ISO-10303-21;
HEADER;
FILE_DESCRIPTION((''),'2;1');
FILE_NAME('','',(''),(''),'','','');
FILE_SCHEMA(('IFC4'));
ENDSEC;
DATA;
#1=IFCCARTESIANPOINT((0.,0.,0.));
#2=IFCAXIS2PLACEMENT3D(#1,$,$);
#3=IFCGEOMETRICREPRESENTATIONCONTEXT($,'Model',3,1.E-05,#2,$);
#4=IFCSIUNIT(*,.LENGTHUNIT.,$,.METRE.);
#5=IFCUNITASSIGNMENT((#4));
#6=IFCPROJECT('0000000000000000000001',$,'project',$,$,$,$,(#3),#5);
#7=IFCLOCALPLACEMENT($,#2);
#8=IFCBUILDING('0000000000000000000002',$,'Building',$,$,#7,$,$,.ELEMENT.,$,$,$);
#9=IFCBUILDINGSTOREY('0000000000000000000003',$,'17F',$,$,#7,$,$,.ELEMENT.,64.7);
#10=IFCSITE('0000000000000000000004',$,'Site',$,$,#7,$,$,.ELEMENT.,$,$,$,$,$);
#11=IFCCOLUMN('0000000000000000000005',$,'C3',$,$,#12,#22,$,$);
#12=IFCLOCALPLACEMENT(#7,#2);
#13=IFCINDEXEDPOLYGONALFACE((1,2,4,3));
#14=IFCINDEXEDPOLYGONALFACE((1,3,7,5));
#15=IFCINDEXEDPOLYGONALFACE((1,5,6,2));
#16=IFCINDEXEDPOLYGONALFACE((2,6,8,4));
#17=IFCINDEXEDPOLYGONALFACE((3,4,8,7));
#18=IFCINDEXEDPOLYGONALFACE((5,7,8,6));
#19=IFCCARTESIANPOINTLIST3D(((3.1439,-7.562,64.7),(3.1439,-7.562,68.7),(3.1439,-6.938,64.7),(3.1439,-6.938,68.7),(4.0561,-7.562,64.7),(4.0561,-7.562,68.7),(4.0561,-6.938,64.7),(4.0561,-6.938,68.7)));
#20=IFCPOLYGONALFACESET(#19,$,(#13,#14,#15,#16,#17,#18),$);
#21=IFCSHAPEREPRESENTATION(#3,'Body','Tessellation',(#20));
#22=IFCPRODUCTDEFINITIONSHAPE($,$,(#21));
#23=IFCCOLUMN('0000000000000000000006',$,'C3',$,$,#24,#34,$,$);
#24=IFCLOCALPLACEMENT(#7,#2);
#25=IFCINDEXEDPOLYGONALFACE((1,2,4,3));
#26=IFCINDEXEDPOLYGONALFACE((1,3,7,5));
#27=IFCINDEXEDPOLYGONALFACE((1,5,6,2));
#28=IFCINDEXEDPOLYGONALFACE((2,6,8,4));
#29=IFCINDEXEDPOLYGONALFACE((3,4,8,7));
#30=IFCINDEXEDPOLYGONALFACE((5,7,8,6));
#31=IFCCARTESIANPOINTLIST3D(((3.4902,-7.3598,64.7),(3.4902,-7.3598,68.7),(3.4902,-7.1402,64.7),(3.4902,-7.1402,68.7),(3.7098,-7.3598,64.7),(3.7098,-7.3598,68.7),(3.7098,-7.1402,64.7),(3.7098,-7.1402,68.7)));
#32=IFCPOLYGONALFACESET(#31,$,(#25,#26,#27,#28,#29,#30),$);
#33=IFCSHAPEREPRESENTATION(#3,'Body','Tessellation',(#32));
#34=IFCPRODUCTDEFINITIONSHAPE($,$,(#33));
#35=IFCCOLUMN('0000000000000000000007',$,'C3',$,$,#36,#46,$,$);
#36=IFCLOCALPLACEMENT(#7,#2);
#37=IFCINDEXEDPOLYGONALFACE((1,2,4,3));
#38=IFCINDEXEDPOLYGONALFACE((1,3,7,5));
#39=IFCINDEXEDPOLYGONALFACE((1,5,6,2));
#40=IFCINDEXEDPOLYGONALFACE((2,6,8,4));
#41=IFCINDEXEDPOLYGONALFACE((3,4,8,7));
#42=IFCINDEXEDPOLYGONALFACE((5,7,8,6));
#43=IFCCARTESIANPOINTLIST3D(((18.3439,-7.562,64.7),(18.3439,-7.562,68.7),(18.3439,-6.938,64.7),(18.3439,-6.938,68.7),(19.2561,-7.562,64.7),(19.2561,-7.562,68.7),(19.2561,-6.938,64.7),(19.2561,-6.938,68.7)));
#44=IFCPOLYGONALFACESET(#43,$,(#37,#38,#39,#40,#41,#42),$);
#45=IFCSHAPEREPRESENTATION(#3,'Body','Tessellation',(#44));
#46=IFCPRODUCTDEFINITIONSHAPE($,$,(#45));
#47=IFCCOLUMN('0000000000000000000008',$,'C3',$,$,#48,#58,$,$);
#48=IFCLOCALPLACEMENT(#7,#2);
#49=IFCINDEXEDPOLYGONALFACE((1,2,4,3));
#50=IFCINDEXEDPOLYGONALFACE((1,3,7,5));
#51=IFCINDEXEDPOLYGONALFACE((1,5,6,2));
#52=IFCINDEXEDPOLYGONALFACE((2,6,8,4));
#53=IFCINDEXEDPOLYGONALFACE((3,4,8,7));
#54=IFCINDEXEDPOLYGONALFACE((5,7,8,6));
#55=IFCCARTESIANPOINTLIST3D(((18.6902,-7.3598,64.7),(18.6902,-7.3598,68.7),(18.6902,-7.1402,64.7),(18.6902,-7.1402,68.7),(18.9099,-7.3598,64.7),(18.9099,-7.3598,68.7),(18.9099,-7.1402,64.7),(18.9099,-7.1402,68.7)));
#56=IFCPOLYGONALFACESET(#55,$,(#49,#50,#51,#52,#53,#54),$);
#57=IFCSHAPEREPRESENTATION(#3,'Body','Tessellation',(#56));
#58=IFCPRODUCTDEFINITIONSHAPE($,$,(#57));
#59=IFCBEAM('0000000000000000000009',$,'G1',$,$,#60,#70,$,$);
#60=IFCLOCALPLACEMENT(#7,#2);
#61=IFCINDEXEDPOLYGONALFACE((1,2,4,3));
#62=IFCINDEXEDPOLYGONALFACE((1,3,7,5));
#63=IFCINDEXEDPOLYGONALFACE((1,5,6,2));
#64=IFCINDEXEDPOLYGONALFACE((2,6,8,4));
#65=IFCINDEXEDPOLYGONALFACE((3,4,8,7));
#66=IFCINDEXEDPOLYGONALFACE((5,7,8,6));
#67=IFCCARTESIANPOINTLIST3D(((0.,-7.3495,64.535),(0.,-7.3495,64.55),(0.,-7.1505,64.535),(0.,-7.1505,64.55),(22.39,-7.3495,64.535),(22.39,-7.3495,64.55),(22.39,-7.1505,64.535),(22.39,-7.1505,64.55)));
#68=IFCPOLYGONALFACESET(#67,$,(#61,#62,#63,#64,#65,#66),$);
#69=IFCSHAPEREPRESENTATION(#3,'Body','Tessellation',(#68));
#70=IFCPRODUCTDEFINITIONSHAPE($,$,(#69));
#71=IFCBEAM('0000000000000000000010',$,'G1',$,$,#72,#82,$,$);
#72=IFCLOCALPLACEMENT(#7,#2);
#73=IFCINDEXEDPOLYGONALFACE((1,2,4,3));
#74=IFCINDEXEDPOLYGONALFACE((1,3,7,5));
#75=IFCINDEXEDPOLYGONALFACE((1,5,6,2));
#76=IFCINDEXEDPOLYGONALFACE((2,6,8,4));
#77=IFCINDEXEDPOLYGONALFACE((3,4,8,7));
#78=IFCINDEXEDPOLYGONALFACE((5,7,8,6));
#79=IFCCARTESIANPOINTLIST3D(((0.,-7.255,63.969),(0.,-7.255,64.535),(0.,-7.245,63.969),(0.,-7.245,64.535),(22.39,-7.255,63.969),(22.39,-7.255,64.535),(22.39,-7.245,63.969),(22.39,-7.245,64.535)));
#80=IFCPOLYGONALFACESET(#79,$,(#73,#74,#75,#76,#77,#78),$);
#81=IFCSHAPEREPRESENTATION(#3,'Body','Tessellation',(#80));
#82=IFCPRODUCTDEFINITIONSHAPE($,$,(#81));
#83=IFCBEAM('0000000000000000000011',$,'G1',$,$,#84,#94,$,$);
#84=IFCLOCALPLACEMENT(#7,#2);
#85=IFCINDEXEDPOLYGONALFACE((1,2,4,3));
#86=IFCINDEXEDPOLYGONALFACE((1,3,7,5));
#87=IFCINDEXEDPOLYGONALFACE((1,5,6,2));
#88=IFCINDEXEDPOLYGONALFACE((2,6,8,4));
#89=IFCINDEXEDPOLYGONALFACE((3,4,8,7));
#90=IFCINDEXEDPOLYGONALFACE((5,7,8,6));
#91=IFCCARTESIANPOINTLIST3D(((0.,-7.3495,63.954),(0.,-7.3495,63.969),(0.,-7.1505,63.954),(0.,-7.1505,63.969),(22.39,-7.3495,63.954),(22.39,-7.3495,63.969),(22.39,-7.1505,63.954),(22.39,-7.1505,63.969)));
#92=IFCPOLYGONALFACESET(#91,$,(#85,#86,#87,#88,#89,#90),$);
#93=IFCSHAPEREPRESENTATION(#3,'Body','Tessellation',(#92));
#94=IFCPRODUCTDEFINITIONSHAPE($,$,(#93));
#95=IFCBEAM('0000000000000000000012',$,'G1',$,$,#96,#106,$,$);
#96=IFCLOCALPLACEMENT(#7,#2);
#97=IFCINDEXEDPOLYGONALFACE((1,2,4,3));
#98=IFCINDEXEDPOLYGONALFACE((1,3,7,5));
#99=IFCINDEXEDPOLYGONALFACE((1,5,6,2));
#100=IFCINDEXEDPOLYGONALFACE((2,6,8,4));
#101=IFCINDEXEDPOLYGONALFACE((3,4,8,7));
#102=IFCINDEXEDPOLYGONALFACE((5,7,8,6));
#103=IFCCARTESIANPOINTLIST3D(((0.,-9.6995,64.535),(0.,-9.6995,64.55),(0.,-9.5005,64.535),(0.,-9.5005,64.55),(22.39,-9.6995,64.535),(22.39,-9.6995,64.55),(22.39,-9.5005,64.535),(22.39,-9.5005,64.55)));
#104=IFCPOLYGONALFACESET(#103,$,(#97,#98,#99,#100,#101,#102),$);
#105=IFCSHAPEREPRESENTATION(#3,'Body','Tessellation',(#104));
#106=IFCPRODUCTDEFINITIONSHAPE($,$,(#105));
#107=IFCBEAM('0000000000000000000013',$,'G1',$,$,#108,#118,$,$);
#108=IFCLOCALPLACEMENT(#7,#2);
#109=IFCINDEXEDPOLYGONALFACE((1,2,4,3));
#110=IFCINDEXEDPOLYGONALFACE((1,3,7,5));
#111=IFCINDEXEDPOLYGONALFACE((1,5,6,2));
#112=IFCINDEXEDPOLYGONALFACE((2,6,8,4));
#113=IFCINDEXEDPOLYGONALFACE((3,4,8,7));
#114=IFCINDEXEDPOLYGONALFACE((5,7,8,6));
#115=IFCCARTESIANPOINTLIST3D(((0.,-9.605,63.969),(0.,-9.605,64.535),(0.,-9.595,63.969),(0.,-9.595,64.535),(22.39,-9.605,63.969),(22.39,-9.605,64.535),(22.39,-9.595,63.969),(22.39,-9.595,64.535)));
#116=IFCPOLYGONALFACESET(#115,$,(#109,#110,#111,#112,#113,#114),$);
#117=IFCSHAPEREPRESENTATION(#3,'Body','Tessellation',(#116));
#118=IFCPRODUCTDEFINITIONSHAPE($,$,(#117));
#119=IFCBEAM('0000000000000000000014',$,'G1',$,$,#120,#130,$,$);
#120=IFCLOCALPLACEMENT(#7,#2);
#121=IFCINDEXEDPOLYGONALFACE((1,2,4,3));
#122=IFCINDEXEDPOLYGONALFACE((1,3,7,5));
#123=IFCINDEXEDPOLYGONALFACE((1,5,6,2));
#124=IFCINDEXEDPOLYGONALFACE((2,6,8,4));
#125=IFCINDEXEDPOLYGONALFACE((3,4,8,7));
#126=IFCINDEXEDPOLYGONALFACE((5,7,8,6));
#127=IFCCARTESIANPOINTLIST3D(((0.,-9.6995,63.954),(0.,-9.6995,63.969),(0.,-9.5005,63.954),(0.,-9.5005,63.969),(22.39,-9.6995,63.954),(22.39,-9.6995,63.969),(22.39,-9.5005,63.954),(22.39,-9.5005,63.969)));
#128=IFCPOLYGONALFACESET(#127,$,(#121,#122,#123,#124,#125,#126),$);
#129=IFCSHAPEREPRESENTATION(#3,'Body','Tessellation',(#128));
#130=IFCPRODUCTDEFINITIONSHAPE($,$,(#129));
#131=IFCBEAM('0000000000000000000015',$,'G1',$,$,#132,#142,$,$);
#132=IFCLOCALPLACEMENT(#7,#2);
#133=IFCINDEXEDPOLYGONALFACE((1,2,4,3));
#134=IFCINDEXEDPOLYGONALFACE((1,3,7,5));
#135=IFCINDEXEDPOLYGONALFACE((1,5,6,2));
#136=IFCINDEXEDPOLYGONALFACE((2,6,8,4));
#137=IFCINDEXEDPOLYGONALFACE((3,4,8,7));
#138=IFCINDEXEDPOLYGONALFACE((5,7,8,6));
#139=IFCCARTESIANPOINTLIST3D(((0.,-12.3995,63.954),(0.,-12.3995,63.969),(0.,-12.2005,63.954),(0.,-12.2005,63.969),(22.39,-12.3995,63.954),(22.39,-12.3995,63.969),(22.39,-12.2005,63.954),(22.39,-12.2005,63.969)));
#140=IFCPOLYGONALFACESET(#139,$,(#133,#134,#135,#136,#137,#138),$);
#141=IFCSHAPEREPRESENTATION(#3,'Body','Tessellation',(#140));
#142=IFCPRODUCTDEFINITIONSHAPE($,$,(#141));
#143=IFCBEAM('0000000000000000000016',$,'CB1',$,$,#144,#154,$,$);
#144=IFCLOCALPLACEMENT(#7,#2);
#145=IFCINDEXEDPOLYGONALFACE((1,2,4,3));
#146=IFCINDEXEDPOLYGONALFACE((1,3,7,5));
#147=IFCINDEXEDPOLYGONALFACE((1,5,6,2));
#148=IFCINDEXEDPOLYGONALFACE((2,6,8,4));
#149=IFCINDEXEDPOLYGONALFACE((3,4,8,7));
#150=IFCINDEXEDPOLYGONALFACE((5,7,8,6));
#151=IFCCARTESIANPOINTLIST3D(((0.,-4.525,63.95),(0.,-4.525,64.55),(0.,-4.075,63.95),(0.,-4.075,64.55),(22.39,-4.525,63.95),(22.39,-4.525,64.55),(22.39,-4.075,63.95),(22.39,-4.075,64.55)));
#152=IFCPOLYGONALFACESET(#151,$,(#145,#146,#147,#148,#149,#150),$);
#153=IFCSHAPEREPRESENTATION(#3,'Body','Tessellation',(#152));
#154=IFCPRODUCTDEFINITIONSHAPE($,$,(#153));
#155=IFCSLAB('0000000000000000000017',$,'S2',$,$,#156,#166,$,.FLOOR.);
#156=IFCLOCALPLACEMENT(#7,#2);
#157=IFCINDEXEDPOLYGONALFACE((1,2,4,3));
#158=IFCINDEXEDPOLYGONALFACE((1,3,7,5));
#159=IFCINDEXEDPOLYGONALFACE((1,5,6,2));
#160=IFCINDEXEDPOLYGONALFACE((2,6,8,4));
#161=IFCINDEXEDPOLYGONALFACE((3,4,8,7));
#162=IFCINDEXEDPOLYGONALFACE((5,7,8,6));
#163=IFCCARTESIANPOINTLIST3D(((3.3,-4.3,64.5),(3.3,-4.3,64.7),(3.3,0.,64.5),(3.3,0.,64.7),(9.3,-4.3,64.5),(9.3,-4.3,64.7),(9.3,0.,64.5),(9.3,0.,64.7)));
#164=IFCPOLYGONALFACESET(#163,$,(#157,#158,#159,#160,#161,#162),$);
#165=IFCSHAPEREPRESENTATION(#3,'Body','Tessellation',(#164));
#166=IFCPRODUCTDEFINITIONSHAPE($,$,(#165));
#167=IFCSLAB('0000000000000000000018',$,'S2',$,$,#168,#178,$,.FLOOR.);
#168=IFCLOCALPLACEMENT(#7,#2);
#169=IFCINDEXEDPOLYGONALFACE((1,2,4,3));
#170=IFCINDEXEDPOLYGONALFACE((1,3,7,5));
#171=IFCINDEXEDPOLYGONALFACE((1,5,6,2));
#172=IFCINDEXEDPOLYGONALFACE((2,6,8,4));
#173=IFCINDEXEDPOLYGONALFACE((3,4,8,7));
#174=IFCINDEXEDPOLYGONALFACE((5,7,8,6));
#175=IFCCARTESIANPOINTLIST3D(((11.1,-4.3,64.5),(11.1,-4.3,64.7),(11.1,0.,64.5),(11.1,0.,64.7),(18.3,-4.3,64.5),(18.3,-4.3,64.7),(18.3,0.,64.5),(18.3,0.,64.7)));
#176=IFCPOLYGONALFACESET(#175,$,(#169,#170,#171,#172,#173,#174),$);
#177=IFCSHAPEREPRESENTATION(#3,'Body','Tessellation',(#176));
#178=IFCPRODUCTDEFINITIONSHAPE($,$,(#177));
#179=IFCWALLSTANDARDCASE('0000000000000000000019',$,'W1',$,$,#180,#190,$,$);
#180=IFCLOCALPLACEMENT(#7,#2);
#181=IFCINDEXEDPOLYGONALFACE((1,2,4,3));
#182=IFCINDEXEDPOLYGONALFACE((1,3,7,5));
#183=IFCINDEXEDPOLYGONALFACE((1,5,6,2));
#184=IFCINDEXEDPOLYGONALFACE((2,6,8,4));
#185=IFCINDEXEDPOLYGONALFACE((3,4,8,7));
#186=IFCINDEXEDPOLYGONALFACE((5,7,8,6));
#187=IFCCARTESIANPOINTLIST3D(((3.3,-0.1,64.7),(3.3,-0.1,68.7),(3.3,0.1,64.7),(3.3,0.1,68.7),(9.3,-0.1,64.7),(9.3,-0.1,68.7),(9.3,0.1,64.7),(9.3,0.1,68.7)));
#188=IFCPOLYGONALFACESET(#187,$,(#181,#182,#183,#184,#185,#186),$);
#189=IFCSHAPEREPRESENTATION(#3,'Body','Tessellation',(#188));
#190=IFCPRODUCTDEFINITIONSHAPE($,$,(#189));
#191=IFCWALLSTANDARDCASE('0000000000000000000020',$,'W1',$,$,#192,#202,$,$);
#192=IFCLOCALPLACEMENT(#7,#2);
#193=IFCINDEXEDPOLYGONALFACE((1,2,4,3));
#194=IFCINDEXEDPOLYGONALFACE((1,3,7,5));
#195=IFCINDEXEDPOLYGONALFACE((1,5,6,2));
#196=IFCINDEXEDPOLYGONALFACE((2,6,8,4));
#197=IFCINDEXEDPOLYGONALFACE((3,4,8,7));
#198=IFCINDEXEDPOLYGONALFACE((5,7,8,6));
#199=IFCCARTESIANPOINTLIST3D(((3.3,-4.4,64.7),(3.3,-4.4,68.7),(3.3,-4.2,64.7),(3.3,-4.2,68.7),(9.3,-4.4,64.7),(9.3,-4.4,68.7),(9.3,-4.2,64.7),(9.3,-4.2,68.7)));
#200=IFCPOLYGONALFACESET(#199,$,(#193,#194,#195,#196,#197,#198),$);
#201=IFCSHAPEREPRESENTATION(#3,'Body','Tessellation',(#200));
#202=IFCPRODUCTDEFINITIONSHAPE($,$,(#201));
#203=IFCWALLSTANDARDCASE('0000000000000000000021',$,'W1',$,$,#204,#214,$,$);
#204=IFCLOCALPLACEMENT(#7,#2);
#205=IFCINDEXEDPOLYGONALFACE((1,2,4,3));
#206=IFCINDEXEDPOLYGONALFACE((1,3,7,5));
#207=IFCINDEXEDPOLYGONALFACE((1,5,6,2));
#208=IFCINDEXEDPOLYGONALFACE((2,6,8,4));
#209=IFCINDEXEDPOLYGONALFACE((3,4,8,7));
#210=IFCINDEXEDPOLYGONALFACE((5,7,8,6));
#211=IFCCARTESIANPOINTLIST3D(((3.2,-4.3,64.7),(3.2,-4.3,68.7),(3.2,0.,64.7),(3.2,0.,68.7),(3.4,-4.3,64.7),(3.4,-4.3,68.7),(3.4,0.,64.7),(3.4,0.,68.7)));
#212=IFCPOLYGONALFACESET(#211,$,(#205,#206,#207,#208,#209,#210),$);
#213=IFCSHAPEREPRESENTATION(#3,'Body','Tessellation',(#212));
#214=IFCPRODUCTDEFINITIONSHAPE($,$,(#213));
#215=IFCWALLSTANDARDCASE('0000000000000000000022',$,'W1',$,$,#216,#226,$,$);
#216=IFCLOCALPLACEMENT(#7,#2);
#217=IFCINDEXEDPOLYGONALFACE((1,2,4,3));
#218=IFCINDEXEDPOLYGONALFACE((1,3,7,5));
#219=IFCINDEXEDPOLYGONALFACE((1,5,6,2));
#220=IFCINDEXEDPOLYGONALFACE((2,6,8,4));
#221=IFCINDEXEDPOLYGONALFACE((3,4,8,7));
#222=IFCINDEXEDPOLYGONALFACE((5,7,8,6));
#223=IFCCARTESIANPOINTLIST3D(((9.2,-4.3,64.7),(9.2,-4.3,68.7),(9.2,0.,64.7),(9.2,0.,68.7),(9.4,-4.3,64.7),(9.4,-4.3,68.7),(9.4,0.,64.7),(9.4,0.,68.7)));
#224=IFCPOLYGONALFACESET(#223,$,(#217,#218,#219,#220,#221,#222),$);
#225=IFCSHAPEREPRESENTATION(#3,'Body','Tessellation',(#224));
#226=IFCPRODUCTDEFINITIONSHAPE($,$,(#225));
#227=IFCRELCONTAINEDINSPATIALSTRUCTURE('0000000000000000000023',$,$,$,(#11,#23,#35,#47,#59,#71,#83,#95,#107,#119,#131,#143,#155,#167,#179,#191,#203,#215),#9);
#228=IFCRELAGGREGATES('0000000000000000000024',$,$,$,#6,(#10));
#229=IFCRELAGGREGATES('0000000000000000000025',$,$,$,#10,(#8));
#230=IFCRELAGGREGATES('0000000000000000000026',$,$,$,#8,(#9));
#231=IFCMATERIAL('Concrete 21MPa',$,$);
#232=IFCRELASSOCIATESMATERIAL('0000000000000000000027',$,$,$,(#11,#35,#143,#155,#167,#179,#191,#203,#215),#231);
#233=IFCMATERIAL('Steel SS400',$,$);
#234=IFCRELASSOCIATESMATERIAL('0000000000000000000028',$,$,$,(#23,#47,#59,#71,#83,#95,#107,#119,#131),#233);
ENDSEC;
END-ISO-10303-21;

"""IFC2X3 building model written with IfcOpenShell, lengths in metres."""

from ifc_helpers import new_model, si_unit, frame, origin, origin_2d, place, context, project, spatial, rectangle, extrude, material, element, save


model = new_model("IFC2X3")

# Units and contexts
model_context = context("Model", 3, precision=1e-05, world=origin())
ifc_project = project(units=[si_unit("LENGTHUNIT", "METRE")], contexts=[model_context])

# Site, building, storey
placement = place(None, origin())
site = spatial("IfcSite", under=ifc_project, at=placement, Name="Site", CompositionType="ELEMENT")
building = spatial("IfcBuilding", under=site, at=placement, Name="Building", CompositionType="ELEMENT")
storey = spatial("IfcBuildingStorey", under=building, at=placement, Name="17F", CompositionType="ELEMENT", Elevation=64.7)

# Columns
ifc_material_1 = material(Name="Concrete 21MPa")
column_1_placement = place(None, frame((3.6, -7.25, 64.7)))
element("IfcColumn", 1, at=column_1_placement, inside=storey, material=ifc_material_1, Name="C3", context=model_context, shape_type="SweptSolid", body=[
    extrude(rectangle(XDim=0.9121, YDim=0.6241, at=origin_2d()), origin(), (0.0, 0.0, 1.0), 4.0),
])
ifc_material_2 = material(Name="Steel SS400")
column_2_placement = place(None, frame((3.6, -7.25, 64.7)))
element("IfcColumn", 2, at=column_2_placement, inside=storey, material=ifc_material_2, Name="C3", context=model_context, shape_type="SweptSolid", body=[
    extrude(rectangle(XDim=0.2197, YDim=0.2197, at=origin_2d()), origin(), (0.0, 0.0, 1.0), 4.0),
])
column_3_placement = place(None, frame((18.8, -7.25, 64.7)))
element("IfcColumn", 3, at=column_3_placement, inside=storey, material=ifc_material_1, Name="C3", context=model_context, shape_type="SweptSolid", body=[
    extrude(rectangle(XDim=0.9121, YDim=0.6241, at=origin_2d()), origin(), (0.0, 0.0, 1.0), 4.0),
])
column_4_placement = place(None, frame((18.8, -7.25, 64.7)))
element("IfcColumn", 4, at=column_4_placement, inside=storey, material=ifc_material_2, Name="C3", context=model_context, shape_type="SweptSolid", body=[
    extrude(rectangle(XDim=0.2197, YDim=0.2197, at=origin_2d()), origin(), (0.0, 0.0, 1.0), 4.0),
])

# Beams
beam_1_placement = place(None, frame((11.195, -7.25, 64.535)))
element("IfcBeam", 5, at=beam_1_placement, inside=storey, material=ifc_material_2, Name="G1", context=model_context, shape_type="SweptSolid", body=[
    extrude(rectangle(XDim=22.39, YDim=0.199, at=origin_2d()), origin(), (0.0, 0.0, 1.0), 0.015),
])
beam_2_placement = place(None, frame((11.195, -7.25, 63.969)))
element("IfcBeam", 6, at=beam_2_placement, inside=storey, material=ifc_material_2, Name="G1", context=model_context, shape_type="SweptSolid", body=[
    extrude(rectangle(XDim=22.39, YDim=0.01, at=origin_2d()), origin(), (0.0, 0.0, 1.0), 0.566),
])
for number, where, name in (
    (7, (11.195, -7.25, 63.954), "G1"),
    (8, (11.195, -9.6, 64.535), "G1"),
):
    element("IfcBeam", number, at=place(None, frame(where)), inside=storey, material=ifc_material_2, Name=name, context=model_context, shape_type="SweptSolid", body=[
        extrude(rectangle(XDim=22.39, YDim=0.199, at=origin_2d()), origin(), (0.0, 0.0, 1.0), 0.015),
    ])
beam_3_placement = place(None, frame((11.195, -9.6, 63.969)))
element("IfcBeam", 9, at=beam_3_placement, inside=storey, material=ifc_material_2, Name="G1", context=model_context, shape_type="SweptSolid", body=[
    extrude(rectangle(XDim=22.39, YDim=0.01, at=origin_2d()), origin(), (0.0, 0.0, 1.0), 0.566),
])
for number, where, name in (
    (10, (11.195, -9.6, 63.954), "G1"),
    (11, (11.195, -12.3, 63.954), "G1"),
):
    element("IfcBeam", number, at=place(None, frame(where)), inside=storey, material=ifc_material_2, Name=name, context=model_context, shape_type="SweptSolid", body=[
        extrude(rectangle(XDim=22.39, YDim=0.199, at=origin_2d()), origin(), (0.0, 0.0, 1.0), 0.015),
    ])
beam_4_placement = place(None, frame((11.195, -4.3, 63.95)))
element("IfcBeam", 12, at=beam_4_placement, inside=storey, material=ifc_material_1, Name="CB1", context=model_context, shape_type="SweptSolid", body=[
    extrude(rectangle(XDim=22.39, YDim=0.45, at=origin_2d()), origin(), (0.0, 0.0, 1.0), 0.6),
])

# Slabs
slab_1_placement = place(None, frame((6.3, -2.15, 64.5)))
element("IfcSlab", 13, at=slab_1_placement, inside=storey, material=ifc_material_1, Name="S2", PredefinedType="FLOOR", context=model_context, shape_type="SweptSolid", body=[
    extrude(rectangle(XDim=6.0, YDim=4.3, at=origin_2d()), origin(), (0.0, 0.0, 1.0), 0.2),
])
slab_2_placement = place(None, frame((14.7, -2.15, 64.5)))
element("IfcSlab", 14, at=slab_2_placement, inside=storey, material=ifc_material_1, Name="S2", PredefinedType="FLOOR", context=model_context, shape_type="SweptSolid", body=[
    extrude(rectangle(XDim=7.2, YDim=4.3, at=origin_2d()), origin(), (0.0, 0.0, 1.0), 0.2),
])

# Walls
for number, where, name in (
    (15, (6.3, 0.0, 64.7), "W1"),
    (16, (6.3, -4.3, 64.7), "W1"),
):
    element("IfcWallStandardCase", number, at=place(None, frame(where)), inside=storey, material=ifc_material_1, Name=name, context=model_context, shape_type="SweptSolid", body=[
        extrude(rectangle(XDim=6.0, YDim=0.2, at=origin_2d()), origin(), (0.0, 0.0, 1.0), 4.0),
    ])
for number, where, name in (
    (17, (3.3, -2.15, 64.7), "W1"),
    (18, (9.3, -2.15, 64.7), "W1"),
):
    element("IfcWallStandardCase", number, at=place(None, frame(where)), inside=storey, material=ifc_material_1, Name=name, context=model_context, shape_type="SweptSolid", body=[
        extrude(rectangle(XDim=0.2, YDim=4.3, at=origin_2d()), origin(), (0.0, 0.0, 1.0), 4.0),
    ])

save(model, "model.ifc")
